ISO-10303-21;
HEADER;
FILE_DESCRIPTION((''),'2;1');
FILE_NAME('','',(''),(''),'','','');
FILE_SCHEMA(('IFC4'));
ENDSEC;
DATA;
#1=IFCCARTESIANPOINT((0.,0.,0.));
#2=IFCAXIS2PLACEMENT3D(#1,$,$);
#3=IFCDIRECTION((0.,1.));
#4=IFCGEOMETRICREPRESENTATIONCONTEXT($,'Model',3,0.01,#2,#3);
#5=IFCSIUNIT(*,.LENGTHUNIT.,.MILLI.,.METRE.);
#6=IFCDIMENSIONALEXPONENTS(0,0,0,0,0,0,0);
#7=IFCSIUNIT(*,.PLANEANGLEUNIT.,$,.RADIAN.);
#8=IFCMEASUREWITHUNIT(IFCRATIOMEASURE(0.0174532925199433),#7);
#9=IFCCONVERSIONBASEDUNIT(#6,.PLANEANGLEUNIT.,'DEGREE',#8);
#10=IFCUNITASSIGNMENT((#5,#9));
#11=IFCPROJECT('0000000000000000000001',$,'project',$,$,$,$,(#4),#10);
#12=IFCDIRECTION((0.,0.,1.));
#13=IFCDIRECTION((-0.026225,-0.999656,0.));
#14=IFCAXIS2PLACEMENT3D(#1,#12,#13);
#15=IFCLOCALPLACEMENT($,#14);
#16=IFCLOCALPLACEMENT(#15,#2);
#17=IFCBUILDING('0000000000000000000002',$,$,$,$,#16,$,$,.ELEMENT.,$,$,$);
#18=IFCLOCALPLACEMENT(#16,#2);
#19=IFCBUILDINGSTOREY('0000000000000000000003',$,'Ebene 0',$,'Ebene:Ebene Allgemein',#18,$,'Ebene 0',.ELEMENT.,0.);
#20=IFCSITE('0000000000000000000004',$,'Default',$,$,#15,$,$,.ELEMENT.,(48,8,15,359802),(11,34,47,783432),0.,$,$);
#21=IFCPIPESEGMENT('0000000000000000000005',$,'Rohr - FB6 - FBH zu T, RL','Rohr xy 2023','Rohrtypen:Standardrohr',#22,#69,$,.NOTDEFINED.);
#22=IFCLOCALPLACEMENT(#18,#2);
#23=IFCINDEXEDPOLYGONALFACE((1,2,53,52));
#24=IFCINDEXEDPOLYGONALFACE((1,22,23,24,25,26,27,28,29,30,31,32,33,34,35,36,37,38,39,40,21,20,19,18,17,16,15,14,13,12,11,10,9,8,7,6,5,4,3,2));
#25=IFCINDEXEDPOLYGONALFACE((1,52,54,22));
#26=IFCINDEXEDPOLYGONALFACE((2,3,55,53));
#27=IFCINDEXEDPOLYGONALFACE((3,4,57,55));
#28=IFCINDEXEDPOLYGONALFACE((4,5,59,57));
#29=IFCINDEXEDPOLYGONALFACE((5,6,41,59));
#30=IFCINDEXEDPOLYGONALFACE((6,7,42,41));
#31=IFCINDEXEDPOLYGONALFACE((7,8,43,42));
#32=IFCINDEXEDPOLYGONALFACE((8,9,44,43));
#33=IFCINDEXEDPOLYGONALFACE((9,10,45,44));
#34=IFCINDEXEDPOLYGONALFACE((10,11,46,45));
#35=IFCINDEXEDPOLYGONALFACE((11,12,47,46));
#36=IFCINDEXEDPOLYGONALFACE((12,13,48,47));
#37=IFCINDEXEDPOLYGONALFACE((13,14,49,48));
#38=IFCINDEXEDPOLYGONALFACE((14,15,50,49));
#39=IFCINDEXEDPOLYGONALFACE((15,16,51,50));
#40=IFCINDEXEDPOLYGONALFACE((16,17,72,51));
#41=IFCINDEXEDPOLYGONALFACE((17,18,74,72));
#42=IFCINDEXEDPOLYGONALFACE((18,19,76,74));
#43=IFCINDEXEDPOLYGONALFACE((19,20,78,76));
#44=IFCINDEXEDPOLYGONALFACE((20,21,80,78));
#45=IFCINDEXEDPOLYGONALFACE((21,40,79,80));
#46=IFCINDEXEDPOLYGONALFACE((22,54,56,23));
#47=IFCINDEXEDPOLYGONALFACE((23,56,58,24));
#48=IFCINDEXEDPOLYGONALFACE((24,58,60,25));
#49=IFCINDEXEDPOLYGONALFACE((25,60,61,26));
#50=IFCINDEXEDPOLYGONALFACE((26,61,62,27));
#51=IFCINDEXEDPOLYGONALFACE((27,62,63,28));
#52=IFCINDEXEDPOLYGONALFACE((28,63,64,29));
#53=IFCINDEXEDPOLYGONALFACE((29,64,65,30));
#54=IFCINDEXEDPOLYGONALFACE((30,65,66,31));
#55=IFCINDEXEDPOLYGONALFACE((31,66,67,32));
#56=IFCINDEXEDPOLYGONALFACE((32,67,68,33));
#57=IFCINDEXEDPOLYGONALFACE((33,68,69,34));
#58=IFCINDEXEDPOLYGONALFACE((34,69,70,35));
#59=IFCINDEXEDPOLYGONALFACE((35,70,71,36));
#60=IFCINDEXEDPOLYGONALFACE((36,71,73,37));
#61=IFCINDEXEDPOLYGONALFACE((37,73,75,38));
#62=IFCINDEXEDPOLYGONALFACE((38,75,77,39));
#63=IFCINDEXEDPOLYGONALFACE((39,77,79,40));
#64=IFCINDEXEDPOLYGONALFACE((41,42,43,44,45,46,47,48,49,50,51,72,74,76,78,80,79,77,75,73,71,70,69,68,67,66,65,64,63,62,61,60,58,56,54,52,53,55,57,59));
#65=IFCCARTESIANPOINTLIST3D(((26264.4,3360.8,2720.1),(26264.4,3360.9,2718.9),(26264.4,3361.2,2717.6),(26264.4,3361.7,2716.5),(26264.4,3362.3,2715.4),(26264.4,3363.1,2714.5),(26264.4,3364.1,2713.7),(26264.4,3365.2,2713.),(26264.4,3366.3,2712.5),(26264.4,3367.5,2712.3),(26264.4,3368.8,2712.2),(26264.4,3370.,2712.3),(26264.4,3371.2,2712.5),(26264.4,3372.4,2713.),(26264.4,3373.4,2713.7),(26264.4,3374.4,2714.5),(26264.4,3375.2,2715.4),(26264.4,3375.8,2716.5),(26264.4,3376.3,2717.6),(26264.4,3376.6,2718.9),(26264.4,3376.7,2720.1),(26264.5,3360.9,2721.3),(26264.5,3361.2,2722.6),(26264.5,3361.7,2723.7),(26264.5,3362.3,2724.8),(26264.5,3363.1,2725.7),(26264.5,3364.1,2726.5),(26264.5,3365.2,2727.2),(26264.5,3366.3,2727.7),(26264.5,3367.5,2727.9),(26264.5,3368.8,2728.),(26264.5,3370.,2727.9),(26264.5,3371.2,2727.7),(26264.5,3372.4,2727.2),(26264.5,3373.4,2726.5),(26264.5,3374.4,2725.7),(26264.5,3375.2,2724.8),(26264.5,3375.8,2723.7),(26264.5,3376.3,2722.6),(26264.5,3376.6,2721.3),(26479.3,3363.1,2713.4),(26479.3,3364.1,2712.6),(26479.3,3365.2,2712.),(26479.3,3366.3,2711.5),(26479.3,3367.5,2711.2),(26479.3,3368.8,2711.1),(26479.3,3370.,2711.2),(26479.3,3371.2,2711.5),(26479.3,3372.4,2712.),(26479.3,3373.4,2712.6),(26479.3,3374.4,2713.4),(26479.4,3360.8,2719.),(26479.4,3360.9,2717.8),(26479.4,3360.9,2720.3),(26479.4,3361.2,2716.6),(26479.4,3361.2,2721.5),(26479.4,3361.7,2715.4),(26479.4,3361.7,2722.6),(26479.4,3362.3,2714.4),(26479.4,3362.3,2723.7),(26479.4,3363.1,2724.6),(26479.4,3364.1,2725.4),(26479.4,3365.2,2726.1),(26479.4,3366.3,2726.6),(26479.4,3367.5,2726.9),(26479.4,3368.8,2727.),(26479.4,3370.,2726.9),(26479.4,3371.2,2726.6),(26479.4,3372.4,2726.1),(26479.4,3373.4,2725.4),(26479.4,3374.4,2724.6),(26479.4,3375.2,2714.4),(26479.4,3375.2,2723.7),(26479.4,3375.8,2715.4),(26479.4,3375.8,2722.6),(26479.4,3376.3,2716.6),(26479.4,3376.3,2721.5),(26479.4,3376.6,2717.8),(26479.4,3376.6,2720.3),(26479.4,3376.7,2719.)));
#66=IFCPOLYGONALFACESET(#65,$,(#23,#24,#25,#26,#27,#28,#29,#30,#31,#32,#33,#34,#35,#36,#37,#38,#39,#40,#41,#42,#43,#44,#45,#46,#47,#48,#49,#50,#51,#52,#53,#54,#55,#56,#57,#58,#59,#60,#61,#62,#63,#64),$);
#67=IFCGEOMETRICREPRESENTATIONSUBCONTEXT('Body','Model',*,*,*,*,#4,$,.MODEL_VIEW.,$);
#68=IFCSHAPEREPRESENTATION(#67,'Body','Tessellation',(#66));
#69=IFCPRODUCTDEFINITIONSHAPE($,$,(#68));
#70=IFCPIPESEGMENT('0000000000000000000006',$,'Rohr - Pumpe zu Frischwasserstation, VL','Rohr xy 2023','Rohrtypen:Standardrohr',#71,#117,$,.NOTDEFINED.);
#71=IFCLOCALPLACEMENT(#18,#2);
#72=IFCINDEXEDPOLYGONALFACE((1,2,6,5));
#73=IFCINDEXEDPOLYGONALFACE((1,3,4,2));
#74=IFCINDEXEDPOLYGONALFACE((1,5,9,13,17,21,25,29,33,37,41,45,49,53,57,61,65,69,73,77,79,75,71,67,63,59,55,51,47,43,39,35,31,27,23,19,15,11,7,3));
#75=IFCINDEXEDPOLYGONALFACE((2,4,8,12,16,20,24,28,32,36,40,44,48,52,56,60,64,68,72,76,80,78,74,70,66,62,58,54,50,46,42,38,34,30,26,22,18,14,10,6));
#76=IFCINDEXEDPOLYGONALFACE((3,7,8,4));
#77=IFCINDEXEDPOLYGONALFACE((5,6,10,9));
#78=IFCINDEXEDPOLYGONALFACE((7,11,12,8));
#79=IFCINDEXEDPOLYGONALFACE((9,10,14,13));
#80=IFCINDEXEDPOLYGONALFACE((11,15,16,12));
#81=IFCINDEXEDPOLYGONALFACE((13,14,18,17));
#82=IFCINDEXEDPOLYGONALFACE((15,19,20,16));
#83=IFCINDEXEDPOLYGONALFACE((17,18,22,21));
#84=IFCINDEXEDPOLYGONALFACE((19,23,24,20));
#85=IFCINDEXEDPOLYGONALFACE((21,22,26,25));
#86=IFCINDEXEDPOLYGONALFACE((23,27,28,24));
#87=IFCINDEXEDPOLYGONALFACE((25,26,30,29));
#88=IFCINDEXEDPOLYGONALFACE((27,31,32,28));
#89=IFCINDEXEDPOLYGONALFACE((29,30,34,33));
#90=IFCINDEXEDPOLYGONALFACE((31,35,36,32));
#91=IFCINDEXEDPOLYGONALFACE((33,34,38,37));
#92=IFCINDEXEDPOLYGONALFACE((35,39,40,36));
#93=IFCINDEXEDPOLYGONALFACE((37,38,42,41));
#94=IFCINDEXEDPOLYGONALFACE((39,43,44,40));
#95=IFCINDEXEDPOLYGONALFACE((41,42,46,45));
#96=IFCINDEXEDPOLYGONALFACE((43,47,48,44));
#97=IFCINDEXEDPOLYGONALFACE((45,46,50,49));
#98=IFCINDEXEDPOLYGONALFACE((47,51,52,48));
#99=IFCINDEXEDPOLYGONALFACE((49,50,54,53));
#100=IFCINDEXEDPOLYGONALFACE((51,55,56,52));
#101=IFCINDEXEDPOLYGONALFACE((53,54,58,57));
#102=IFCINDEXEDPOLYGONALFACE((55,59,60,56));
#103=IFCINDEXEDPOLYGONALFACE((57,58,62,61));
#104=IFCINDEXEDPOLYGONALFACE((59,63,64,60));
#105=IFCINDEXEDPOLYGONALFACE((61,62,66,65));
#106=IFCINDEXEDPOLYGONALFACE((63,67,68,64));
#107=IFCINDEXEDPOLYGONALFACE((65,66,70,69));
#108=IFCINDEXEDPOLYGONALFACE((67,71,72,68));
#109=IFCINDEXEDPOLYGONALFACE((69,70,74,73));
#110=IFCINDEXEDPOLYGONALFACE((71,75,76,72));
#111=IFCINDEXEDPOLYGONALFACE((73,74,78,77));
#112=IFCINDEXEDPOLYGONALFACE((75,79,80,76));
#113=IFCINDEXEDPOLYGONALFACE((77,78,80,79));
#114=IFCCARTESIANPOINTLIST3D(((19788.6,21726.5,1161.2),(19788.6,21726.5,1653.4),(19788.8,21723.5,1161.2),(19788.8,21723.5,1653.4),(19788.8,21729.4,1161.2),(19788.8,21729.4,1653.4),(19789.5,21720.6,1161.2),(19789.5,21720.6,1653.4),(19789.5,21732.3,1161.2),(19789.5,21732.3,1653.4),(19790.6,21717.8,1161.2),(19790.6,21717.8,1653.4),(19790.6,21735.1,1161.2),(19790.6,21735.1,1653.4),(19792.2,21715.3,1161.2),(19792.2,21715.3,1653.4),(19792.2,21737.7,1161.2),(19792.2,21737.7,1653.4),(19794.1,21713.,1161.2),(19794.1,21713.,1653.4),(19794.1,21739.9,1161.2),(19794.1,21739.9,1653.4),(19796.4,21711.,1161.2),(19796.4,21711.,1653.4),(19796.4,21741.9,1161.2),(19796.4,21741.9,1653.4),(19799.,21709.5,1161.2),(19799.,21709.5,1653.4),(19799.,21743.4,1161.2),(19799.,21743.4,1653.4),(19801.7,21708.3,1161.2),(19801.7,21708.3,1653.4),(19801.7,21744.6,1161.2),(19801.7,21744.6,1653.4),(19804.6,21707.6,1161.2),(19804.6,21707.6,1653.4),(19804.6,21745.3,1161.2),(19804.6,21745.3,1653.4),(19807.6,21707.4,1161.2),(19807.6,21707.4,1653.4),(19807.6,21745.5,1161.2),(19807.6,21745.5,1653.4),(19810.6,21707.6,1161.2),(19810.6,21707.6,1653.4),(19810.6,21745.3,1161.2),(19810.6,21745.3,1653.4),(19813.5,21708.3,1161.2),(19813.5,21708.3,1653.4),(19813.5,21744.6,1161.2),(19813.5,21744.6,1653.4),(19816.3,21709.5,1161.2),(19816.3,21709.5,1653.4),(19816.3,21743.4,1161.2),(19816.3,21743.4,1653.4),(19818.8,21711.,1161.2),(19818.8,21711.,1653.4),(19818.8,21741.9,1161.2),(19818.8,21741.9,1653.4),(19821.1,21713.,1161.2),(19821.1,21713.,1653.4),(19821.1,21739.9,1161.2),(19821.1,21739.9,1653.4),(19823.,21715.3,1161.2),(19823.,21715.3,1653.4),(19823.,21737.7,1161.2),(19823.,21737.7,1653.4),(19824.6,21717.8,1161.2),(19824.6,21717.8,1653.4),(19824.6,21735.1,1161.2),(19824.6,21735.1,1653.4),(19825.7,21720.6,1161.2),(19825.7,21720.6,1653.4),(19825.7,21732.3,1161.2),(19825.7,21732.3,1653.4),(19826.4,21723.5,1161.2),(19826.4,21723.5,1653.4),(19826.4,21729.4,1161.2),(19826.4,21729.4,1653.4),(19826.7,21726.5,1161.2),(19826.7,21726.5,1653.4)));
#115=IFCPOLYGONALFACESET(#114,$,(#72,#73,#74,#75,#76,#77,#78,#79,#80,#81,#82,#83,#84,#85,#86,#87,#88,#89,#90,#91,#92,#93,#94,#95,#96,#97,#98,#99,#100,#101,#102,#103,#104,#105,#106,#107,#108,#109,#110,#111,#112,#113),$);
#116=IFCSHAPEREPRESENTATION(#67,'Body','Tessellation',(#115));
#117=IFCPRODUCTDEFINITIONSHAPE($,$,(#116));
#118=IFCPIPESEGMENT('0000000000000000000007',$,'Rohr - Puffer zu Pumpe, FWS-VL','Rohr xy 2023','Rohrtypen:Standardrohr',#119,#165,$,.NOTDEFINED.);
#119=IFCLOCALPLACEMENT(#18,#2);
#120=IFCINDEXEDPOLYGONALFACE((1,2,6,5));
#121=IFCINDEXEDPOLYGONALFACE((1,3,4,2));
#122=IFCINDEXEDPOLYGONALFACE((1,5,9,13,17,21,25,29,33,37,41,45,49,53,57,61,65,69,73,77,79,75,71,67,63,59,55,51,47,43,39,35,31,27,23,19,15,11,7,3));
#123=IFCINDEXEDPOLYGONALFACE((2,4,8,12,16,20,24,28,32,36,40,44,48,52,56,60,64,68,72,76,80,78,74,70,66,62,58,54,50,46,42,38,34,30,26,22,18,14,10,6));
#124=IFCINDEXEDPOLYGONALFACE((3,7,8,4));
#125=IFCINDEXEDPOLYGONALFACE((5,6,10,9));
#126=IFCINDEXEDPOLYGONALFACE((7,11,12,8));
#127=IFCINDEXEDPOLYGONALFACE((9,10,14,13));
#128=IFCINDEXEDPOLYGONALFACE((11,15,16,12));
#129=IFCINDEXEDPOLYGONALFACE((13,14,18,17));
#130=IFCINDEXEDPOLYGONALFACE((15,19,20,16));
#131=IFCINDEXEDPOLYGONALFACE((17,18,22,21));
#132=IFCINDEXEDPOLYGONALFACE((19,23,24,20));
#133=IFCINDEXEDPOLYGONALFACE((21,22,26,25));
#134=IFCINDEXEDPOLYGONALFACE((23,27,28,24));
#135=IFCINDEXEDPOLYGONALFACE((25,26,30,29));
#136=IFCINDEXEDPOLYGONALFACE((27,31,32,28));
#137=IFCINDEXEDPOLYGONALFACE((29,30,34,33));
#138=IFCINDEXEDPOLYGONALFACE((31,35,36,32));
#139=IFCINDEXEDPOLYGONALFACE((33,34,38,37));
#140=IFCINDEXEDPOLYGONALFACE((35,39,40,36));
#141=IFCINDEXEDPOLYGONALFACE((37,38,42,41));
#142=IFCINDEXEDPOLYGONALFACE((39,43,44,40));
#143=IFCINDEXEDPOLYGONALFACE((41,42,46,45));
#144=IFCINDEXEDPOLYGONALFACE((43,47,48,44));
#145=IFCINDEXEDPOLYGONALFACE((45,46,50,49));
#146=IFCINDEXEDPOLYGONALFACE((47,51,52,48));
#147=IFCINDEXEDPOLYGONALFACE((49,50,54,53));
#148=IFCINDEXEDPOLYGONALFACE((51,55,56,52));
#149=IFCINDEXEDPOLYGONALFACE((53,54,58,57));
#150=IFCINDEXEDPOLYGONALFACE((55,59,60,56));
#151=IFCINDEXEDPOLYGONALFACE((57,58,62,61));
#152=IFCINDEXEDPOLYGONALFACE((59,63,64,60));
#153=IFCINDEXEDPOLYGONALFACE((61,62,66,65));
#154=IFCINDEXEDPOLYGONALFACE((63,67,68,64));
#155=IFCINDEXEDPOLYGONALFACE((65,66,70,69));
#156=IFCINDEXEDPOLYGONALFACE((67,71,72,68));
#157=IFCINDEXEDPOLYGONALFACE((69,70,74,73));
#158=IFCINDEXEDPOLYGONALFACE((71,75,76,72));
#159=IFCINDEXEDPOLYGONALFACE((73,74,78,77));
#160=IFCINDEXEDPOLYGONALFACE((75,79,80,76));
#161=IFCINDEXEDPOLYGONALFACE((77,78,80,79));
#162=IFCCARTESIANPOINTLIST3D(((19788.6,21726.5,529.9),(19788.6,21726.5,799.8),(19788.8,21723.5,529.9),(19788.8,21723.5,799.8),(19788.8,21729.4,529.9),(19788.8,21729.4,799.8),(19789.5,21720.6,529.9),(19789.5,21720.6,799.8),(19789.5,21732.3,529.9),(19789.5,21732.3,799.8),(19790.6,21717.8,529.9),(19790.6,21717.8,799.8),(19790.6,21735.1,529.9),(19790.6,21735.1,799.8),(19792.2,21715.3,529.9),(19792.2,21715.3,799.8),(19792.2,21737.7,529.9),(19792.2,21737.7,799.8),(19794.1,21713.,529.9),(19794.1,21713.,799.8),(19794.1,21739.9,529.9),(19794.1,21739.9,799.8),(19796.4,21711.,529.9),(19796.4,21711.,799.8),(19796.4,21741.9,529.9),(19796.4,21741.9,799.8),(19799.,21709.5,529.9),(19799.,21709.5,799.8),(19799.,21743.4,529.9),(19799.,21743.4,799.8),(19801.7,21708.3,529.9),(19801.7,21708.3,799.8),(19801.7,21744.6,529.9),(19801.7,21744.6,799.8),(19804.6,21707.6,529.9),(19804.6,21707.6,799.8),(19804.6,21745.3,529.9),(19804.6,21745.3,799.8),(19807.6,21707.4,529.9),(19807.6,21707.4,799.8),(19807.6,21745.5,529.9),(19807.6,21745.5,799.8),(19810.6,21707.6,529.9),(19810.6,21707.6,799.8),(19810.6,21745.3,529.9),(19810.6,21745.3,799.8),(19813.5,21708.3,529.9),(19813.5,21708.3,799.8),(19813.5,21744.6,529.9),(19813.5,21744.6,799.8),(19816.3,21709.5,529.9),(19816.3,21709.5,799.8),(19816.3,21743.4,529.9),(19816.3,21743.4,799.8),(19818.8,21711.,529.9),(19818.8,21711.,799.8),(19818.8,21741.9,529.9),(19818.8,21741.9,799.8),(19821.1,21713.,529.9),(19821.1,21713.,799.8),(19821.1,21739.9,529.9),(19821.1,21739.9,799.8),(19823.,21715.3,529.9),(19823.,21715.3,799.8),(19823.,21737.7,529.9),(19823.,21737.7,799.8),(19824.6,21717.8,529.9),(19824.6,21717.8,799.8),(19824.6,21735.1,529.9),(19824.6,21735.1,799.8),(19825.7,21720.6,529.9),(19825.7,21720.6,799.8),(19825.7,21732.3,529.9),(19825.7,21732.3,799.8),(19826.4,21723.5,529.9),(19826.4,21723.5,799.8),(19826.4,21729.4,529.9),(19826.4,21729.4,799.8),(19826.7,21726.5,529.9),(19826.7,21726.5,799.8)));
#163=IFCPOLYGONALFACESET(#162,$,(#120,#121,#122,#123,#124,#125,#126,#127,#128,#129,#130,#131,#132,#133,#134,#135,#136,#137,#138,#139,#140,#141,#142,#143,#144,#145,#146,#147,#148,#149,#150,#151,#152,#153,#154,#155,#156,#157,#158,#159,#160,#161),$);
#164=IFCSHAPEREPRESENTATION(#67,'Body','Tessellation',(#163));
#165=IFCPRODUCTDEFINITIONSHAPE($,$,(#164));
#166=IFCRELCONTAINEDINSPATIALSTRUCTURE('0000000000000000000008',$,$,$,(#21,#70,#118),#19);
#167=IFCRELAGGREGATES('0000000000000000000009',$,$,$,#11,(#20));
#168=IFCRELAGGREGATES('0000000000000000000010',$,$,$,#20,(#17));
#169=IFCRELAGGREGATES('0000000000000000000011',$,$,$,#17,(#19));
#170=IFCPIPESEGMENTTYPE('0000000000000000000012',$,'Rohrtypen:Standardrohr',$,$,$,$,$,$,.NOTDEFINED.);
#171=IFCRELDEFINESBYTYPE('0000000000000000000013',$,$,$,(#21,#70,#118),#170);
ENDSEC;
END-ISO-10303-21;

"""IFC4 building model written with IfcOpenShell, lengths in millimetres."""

from ifc_helpers import new_model, entity, si_unit, converted_unit, direction, frame, origin, place, context, subcontext, project, spatial, indexed_curve, outline, extrude, type_object, element, save


model = new_model("IFC4")

# Units and contexts
model_context = context("Model", 3, precision=0.01, world=origin(), true_north=direction((0.0, 1.0)))
body_context = subcontext(model_context, "Body", "Model", "MODEL_VIEW")
ifc_project = project(units=[si_unit("LENGTHUNIT", "METRE", prefix="MILLI"), converted_unit("PLANEANGLEUNIT", "DEGREE", entity("IfcRatioMeasure", 0.0174532925199433), si_unit("PLANEANGLEUNIT", "RADIAN"), dimensions=[0, 0, 0, 0, 0, 0, 0])], contexts=[model_context])

# Site, building, storey
site_placement = place(None, frame((0.0, 0.0, 0.0), z_axis=(0.0, 0.0, 1.0), x_axis=(-0.026225, -0.999656, 0.0)))
site = spatial("IfcSite", under=ifc_project, at=site_placement, Name="Default", CompositionType="ELEMENT", RefLatitude=(48, 8, 15, 359802), RefLongitude=(11, 34, 47, 783432), RefElevation=0.0)
building_placement = place(site_placement, origin())
building = spatial("IfcBuilding", under=site, at=building_placement, CompositionType="ELEMENT")
storey_placement = place(building_placement, origin())
storey = spatial("IfcBuildingStorey", under=building, at=storey_placement, Name="Ebene 0", ObjectType="Ebene:Ebene Allgemein", LongName="Ebene 0", CompositionType="ELEMENT", Elevation=0.0)

# Pipe segments
pipe_segment_type = type_object("IfcPipeSegmentType", Name="Rohrtypen:Standardrohr", PredefinedType="NOTDEFINED")
pipe_segment_1_placement = place(storey_placement, origin())
element("IfcPipeSegment", 1, at=pipe_segment_1_placement, inside=storey, type_object=pipe_segment_type, Name="Rohr - FB6 - FBH zu T, RL", Description="Rohr xy 2023", ObjectType="Rohrtypen:Standardrohr", PredefinedType="NOTDEFINED", context=body_context, shape_type="SweptSolid", body=[
    extrude(outline(indexed_curve([(7.9, 0.0), (7.8, 1.2), (7.6, 2.5), (7.1, 3.6), (6.4, 4.7), (5.6, 5.6), (4.7, 6.4), (3.6, 7.1), (2.5, 7.6), (1.2, 7.8), (0.0, 7.9), (-1.2, 7.8), (-2.5, 7.6), (-3.6, 7.1), (-4.7, 6.4), (-5.6, 5.6), (-6.4, 4.7), (-7.1, 3.6), (-7.6, 2.5), (-7.8, 1.2), (-7.9, 0.0), (-7.8, -1.2), (-7.6, -2.5), (-7.1, -3.6), (-6.4, -4.7), (-5.6, -5.6), (-4.7, -6.4), (-3.6, -7.1), (-2.5, -7.6), (-1.2, -7.8), (0.0, -7.9), (1.2, -7.8), (2.5, -7.6), (3.6, -7.1), (4.7, -6.4), (5.6, -5.6), (6.4, -4.7), (7.1, -3.6), (7.6, -2.5), (7.8, -1.2), (7.9, 0.0)], self_intersect=False)), frame((26479.4, 3368.8, 2719.0), z_axis=(-0.999988, 0.0, 0.005), x_axis=(0.0, 1.0, 0.0)), (0.0, 0.0, 1.0), 214.9),
])
pipe_segment_2_placement = place(storey_placement, origin())
element("IfcPipeSegment", 2, at=pipe_segment_2_placement, inside=storey, type_object=pipe_segment_type, Name="Rohr - Pumpe zu Frischwasserstation, VL", Description="Rohr xy 2023", ObjectType="Rohrtypen:Standardrohr", PredefinedType="NOTDEFINED", context=body_context, shape_type="SweptSolid", body=[
    extrude(outline(indexed_curve([(19.1, 0.0), (18.8, 3.0), (18.1, 5.9), (17.0, 8.6), (15.4, 11.2), (13.5, 13.5), (11.2, 15.4), (8.6, 17.0), (5.9, 18.1), (3.0, 18.8), (0.0, 19.0), (-3.0, 18.8), (-5.9, 18.1), (-8.6, 17.0), (-11.2, 15.4), (-13.5, 13.5), (-15.4, 11.2), (-17.0, 8.6), (-18.1, 5.9), (-18.8, 3.0), (-19.1, 0.0), (-18.8, -3.0), (-18.1, -5.9), (-17.0, -8.6), (-15.4, -11.2), (-13.5, -13.5), (-11.2, -15.4), (-8.6, -17.0), (-5.9, -18.1), (-3.0, -18.8), (0.0, -19.0), (3.0, -18.8), (5.9, -18.1), (8.6, -17.0), (11.2, -15.4), (13.5, -13.5), (15.4, -11.2), (17.0, -8.6), (18.1, -5.9), (18.8, -3.0), (19.1, 0.0)], self_intersect=False)), frame((19807.6, 21726.5, 1161.2), z_axis=(0.000002, 0.000002, 1.0), x_axis=(-1.0, 0.0, 0.000002)), (0.0, 0.0, 1.0), 492.1),
])
pipe_segment_3_placement = place(storey_placement, origin())
element("IfcPipeSegment", 3, at=pipe_segment_3_placement, inside=storey, type_object=pipe_segment_type, Name="Rohr - Puffer zu Pumpe, FWS-VL", Description="Rohr xy 2023", ObjectType="Rohrtypen:Standardrohr", PredefinedType="NOTDEFINED", context=body_context, shape_type="SweptSolid", body=[
    extrude(outline(indexed_curve([(19.1, 0.0), (18.8, 3.0), (18.1, 5.9), (17.0, 8.6), (15.4, 11.2), (13.5, 13.5), (11.2, 15.4), (8.6, 17.0), (5.9, 18.1), (3.0, 18.8), (0.0, 19.0), (-3.0, 18.8), (-5.9, 18.1), (-8.6, 17.0), (-11.2, 15.4), (-13.5, 13.5), (-15.4, 11.2), (-17.0, 8.6), (-18.1, 5.9), (-18.8, 3.0), (-19.1, 0.0), (-18.8, -3.0), (-18.1, -5.9), (-17.0, -8.6), (-15.4, -11.2), (-13.5, -13.5), (-11.2, -15.4), (-8.6, -17.0), (-5.9, -18.1), (-3.0, -18.8), (0.0, -19.0), (3.0, -18.8), (5.9, -18.1), (8.6, -17.0), (11.2, -15.4), (13.5, -13.5), (15.4, -11.2), (17.0, -8.6), (18.1, -5.9), (18.8, -3.0), (19.1, 0.0)], self_intersect=False)), frame((19807.6, 21726.5, 529.9), z_axis=(0.000002, 0.000002, 1.0), x_axis=(-1.0, 0.0, 0.000002)), (0.0, 0.0, 1.0), 269.9),
])

save(model, "model.ifc")
